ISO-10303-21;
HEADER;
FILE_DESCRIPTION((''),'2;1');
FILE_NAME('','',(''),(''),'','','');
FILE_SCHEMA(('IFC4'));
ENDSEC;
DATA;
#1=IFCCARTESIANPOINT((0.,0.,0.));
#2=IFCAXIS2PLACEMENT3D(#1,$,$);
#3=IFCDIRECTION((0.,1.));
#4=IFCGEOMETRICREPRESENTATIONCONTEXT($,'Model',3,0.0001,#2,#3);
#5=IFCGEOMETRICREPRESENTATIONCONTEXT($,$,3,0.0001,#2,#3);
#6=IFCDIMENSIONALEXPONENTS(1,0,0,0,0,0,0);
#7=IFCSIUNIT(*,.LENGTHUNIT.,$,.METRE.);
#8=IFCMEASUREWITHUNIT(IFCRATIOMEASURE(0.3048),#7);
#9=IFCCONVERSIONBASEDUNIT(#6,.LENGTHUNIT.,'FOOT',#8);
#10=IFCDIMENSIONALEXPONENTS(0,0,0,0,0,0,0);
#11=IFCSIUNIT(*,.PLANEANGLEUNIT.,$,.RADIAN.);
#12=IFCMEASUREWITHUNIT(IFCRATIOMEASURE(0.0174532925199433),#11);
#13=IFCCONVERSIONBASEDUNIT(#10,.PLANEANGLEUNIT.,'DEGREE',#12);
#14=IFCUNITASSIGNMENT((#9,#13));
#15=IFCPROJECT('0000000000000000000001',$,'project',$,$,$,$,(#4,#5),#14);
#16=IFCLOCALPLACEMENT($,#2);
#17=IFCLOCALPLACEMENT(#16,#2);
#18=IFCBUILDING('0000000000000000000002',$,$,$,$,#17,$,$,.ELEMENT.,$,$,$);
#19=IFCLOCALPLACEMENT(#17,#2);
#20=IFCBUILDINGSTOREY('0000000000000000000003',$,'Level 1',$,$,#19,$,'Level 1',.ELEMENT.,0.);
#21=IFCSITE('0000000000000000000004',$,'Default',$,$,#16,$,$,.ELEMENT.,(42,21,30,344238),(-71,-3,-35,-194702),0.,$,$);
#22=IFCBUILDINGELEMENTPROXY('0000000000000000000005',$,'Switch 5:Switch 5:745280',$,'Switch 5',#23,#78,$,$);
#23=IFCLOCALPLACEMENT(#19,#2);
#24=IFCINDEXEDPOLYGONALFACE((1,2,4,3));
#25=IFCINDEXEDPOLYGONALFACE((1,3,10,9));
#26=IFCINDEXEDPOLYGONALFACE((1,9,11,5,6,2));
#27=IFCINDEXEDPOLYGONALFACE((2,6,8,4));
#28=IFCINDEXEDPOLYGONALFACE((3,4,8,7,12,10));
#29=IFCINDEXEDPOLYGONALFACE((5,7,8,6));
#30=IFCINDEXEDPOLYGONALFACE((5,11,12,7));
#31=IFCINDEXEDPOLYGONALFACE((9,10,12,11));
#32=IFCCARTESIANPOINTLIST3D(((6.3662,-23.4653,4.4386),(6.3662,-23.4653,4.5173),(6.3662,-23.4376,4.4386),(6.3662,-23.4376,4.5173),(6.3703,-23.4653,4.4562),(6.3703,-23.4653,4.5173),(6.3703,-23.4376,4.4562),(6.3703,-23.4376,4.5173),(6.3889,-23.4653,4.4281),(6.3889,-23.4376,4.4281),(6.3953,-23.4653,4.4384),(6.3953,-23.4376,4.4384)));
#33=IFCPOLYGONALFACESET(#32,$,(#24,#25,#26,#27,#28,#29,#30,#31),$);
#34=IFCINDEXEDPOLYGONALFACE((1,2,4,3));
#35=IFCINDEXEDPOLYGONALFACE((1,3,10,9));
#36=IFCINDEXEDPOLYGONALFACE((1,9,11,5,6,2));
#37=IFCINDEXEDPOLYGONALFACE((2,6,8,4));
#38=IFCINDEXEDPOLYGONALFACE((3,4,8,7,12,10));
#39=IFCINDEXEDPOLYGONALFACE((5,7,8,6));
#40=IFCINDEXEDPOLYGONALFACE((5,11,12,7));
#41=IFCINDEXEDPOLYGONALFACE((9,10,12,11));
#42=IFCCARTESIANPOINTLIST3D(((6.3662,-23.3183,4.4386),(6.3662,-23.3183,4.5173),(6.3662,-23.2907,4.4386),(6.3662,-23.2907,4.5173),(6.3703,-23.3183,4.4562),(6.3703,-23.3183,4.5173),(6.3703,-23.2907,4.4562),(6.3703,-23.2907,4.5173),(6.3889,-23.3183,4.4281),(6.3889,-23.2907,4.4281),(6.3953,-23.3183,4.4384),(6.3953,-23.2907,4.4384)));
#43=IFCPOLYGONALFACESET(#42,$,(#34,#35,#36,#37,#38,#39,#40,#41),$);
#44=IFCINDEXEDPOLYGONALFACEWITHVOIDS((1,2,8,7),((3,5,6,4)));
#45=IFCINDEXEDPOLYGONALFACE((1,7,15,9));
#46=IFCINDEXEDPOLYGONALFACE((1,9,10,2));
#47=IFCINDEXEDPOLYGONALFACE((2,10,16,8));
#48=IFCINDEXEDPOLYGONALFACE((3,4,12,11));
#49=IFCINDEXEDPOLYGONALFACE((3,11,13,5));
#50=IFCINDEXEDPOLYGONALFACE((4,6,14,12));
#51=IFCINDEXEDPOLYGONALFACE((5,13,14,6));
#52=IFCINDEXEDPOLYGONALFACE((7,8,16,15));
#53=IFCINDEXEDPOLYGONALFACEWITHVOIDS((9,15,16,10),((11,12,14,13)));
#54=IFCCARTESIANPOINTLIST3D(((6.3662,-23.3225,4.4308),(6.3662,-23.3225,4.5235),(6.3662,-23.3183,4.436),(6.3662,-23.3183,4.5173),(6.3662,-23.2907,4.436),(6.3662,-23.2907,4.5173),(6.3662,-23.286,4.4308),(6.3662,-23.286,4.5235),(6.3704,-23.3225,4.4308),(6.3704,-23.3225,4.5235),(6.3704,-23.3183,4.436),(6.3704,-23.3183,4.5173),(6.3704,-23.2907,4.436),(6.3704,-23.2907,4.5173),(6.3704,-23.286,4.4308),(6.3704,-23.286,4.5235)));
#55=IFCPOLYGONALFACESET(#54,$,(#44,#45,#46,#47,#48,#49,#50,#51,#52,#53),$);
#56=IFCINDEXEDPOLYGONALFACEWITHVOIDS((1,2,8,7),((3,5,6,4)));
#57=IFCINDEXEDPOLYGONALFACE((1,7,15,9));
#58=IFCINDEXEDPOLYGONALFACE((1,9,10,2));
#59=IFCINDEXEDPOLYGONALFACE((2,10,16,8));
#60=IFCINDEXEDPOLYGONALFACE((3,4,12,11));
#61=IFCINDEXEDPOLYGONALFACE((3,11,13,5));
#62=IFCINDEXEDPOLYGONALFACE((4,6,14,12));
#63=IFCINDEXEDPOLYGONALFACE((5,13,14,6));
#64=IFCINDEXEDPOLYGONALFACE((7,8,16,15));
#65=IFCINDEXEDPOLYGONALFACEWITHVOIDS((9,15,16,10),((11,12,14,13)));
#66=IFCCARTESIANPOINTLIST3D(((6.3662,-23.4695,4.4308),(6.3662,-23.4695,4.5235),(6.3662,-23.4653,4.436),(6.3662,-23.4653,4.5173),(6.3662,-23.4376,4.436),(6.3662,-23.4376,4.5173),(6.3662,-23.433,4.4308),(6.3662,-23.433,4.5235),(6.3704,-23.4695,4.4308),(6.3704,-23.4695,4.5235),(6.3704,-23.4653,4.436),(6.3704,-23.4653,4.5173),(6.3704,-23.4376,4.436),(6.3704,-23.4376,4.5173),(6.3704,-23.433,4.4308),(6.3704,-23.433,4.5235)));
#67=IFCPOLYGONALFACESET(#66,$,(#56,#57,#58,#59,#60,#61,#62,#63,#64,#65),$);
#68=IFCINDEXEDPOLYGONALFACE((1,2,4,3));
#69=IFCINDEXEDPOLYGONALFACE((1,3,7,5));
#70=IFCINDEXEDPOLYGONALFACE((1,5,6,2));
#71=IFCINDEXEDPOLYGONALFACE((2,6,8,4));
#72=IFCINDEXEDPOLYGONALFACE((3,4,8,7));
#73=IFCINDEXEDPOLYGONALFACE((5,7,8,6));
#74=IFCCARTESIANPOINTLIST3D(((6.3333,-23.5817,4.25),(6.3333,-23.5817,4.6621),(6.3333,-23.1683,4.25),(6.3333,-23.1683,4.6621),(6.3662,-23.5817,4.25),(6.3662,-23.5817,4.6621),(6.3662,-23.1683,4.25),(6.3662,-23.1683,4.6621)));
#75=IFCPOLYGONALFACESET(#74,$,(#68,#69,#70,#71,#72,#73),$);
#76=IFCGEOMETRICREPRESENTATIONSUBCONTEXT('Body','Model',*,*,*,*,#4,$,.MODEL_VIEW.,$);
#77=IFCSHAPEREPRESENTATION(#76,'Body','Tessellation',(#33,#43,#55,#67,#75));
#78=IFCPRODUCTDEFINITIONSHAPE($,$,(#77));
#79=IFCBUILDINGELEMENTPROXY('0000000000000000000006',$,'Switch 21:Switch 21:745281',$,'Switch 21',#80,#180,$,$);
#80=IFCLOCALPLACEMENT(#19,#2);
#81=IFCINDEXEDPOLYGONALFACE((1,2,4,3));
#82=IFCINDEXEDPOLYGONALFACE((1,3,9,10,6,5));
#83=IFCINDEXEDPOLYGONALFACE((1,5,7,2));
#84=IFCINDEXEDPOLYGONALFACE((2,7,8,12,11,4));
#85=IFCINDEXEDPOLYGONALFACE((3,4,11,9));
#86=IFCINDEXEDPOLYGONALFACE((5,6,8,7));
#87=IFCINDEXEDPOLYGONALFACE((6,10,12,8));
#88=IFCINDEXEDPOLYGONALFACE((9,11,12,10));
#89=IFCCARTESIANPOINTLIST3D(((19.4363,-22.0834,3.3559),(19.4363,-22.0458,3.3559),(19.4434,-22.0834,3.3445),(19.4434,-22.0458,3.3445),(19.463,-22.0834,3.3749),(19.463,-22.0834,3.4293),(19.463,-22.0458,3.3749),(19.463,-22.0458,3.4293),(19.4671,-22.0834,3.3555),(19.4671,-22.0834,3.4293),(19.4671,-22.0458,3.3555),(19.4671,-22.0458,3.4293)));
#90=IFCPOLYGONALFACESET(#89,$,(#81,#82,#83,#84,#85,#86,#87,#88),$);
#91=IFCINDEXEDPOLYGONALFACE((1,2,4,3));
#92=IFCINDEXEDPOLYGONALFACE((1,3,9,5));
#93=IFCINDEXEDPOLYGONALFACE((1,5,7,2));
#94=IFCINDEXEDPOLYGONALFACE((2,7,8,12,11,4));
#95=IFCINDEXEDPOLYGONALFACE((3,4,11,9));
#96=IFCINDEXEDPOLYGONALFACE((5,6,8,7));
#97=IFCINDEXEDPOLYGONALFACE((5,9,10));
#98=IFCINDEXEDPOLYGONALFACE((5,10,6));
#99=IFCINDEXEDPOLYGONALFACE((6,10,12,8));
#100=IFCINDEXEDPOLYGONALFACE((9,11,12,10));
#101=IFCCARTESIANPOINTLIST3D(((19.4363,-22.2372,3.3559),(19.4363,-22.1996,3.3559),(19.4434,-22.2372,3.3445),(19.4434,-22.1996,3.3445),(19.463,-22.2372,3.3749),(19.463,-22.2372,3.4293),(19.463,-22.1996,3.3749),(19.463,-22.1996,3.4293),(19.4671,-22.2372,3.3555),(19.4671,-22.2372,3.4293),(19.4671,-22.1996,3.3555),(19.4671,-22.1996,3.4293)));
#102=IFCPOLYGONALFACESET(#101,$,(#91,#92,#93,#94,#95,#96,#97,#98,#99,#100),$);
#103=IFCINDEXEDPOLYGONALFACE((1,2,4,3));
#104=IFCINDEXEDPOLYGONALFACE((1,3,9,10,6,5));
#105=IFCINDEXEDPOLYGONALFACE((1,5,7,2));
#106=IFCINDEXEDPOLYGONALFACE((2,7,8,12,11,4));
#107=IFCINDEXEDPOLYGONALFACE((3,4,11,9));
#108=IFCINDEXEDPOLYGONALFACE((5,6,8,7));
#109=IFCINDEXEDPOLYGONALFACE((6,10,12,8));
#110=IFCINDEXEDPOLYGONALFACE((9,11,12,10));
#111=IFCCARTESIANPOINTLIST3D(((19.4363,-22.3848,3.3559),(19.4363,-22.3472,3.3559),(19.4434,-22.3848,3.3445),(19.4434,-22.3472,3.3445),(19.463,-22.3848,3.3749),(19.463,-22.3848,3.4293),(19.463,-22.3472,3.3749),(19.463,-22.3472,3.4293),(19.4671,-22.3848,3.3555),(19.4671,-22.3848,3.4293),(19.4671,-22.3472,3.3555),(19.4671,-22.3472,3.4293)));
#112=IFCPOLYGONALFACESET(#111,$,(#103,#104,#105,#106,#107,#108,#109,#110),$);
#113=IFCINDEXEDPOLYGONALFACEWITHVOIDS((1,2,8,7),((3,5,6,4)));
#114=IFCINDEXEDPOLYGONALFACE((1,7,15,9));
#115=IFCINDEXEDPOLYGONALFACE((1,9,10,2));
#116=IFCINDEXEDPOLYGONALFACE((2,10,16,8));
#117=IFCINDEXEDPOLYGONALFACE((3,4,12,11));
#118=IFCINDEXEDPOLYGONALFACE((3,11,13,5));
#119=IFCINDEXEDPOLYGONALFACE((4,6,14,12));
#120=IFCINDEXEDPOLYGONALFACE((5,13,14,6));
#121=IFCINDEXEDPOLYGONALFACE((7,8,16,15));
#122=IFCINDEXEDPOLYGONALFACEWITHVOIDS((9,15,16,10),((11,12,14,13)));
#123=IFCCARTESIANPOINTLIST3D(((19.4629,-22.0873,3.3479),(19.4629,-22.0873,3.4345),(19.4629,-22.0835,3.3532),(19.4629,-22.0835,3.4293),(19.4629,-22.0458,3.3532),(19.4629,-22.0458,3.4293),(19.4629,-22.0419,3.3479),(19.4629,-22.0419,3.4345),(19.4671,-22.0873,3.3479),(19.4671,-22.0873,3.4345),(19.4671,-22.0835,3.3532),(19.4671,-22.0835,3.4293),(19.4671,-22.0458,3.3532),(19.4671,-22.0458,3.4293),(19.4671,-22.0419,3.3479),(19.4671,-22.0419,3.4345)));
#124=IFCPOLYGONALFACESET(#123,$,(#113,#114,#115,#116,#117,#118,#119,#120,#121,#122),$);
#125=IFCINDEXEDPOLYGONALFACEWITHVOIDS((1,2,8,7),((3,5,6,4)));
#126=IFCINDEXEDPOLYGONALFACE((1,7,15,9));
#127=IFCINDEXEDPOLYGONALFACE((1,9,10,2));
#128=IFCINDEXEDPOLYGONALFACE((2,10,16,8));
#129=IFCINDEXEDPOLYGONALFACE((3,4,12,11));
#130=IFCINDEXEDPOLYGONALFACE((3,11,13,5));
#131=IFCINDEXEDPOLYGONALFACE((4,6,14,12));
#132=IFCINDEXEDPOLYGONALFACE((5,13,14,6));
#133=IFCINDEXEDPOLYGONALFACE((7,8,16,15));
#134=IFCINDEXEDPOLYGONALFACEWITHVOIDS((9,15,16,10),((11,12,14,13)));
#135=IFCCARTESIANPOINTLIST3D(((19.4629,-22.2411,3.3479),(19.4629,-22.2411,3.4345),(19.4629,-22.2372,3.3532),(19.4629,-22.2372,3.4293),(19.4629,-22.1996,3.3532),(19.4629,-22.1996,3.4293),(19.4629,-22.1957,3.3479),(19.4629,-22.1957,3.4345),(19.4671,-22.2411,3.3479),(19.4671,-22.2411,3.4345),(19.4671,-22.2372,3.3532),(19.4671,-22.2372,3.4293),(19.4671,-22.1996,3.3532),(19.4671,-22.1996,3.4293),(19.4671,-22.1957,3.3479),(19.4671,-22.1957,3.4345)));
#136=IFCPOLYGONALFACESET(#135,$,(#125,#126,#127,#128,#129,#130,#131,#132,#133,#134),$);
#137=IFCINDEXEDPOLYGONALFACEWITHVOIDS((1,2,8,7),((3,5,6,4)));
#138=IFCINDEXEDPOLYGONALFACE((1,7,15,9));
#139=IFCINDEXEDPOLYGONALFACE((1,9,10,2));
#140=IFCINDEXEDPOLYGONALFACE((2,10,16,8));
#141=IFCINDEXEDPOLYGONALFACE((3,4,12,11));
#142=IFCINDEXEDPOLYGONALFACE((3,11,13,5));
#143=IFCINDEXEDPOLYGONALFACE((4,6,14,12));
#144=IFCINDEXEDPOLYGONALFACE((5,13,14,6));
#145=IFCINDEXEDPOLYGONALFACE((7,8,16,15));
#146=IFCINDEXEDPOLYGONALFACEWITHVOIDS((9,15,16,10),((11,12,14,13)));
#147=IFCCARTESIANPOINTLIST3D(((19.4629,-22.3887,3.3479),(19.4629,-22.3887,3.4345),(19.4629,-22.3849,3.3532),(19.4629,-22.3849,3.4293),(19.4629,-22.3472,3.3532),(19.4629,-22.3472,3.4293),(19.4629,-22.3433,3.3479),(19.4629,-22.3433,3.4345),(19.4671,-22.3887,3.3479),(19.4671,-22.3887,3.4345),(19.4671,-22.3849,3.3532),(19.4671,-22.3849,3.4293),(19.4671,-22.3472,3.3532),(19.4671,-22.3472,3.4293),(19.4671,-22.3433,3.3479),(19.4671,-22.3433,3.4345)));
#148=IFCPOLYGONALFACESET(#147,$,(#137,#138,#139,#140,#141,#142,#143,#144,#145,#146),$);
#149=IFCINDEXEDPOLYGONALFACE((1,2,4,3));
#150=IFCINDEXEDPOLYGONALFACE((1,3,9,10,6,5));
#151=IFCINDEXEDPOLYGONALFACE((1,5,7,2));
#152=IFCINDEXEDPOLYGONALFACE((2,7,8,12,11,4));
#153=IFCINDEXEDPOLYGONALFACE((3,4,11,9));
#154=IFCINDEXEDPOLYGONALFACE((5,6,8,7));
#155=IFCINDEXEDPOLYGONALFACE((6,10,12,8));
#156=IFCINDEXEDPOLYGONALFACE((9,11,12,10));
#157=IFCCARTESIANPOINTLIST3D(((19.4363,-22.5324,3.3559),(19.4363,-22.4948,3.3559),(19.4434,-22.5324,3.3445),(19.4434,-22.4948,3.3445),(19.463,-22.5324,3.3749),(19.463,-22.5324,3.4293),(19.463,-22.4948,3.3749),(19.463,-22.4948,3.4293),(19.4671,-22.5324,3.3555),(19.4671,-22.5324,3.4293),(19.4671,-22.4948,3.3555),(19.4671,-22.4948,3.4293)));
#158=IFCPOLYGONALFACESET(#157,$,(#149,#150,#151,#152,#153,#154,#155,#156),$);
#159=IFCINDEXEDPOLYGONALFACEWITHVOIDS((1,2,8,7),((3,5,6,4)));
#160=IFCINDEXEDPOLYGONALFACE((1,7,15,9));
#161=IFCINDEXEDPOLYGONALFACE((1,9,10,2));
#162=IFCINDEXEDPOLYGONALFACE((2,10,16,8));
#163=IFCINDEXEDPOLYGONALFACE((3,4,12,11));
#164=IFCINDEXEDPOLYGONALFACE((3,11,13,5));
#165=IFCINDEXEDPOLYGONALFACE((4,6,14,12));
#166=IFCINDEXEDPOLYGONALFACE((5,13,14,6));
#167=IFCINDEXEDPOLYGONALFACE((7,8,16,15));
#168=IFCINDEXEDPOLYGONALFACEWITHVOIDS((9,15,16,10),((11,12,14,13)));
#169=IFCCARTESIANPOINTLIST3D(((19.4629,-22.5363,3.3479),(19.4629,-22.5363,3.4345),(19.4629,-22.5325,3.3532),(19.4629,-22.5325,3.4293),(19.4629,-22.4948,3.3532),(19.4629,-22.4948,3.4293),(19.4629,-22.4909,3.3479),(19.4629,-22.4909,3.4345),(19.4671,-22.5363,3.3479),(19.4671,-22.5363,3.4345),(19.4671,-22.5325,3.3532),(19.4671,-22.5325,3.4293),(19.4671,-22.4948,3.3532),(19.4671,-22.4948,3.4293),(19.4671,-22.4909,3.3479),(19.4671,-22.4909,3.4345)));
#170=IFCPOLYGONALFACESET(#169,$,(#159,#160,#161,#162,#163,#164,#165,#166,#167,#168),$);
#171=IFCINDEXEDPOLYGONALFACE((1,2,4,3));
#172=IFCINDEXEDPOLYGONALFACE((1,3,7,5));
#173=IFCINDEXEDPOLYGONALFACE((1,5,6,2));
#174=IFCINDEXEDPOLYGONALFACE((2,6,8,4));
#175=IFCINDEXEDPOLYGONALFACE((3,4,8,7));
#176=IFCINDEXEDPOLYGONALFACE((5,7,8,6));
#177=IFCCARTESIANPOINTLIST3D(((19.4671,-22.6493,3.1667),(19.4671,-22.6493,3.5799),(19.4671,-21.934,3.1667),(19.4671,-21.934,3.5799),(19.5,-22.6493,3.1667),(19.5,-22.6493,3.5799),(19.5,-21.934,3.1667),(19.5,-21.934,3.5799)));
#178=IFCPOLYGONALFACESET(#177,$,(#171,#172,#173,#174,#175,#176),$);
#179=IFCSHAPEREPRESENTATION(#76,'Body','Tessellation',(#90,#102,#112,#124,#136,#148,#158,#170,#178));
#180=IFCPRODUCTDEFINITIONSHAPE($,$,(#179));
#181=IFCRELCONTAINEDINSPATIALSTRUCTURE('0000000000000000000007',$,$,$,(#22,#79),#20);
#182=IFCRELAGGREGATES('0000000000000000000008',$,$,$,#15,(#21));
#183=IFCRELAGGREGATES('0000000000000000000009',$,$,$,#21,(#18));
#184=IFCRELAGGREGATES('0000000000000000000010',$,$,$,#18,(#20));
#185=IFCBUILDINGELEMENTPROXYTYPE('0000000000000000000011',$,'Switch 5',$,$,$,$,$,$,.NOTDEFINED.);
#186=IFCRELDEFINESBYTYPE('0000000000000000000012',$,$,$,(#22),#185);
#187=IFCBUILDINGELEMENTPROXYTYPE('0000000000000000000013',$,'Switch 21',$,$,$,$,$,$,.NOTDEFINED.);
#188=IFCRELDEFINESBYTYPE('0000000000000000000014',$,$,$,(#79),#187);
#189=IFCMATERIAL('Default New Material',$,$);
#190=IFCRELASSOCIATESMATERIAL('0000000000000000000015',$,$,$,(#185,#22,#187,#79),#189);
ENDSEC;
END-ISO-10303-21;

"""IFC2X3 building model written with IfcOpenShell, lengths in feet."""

from ifc_helpers import new_model, entity, si_unit, converted_unit, direction, frame, origin, origin_2d_with_axis, place, context, subcontext, project, spatial, polyline, rectangle, outline, extrude, source, transform, mapped, material, type_object, type_shapes, element, save


model = new_model("IFC2X3")

# Units and contexts
model_context = context("Model", 3, precision=0.0001, world=origin(), true_north=direction((0.0, 1.0)))
context_of_model = context(None, 3, precision=0.0001, world=origin(), true_north=direction((0.0, 1.0)))
body_context = subcontext(model_context, "Body", "Model", "MODEL_VIEW")
ifc_project = project(units=[converted_unit("LENGTHUNIT", "FOOT", entity("IfcRatioMeasure", 0.3048), si_unit("LENGTHUNIT", "METRE"), dimensions=[1, 0, 0, 0, 0, 0, 0]), converted_unit("PLANEANGLEUNIT", "DEGREE", entity("IfcRatioMeasure", 0.0174532925199433), si_unit("PLANEANGLEUNIT", "RADIAN"), dimensions=[0, 0, 0, 0, 0, 0, 0])], contexts=[model_context, context_of_model])

# Site, building, storey
site_placement = place(None, origin())
site = spatial("IfcSite", under=ifc_project, at=site_placement, Name="Default", CompositionType="ELEMENT", RefLatitude=(42, 21, 30, 344238), RefLongitude=(-71, -3, -35, -194702), RefElevation=0.0)
building_placement = place(site_placement, origin())
building = spatial("IfcBuilding", under=site, at=building_placement, CompositionType="ELEMENT")
storey_placement = place(building_placement, origin())
storey = spatial("IfcBuildingStorey", under=building, at=storey_placement, Name="Level 1", LongName="Level 1", CompositionType="ELEMENT", Elevation=0.0)

# Shared definitions
ifc_material = material(Name="Default New Material")

# Building element proxies
building_element_proxy_type_1 = type_object("IfcBuildingElementProxyType", Name="Switch 5", PredefinedType="NOTDEFINED", material=ifc_material)
shared_shape_1 = source(origin(), body_context, "Body", "SweptSolid", [
    extrude(outline(polyline([(-0.0255, -0.0308), (-0.0133, -0.0308), (-0.0115, -0.0002), (0.0405, 0.0322), (0.0383, 0.0356), (-0.0285, -0.006), (-0.0255, -0.0308)])), frame((0.0626, 0.0429, 0.216), z_axis=(1.0, 0.0, 0.0), x_axis=(0.0, 0.528865, 0.848706)), (0.0, 0.0, 1.0), 0.0277),
    extrude(outline(polyline([(-0.0255, -0.0308), (-0.0133, -0.0308), (-0.0115, -0.0002), (0.0405, 0.0322), (0.0383, 0.0356), (-0.0285, -0.006), (-0.0255, -0.0308)])), frame((-0.0843, 0.0429, 0.216), z_axis=(1.0, 0.0, 0.0), x_axis=(0.0, 0.528865, 0.848706)), (0.0, 0.0, 1.0), 0.0277),
    extrude(outline(polyline([(-0.0464, -0.0182), (0.0464, -0.0182), (0.0464, 0.0182), (-0.0464, 0.0182), (-0.0464, -0.0182)]), holes=[polyline([(-0.0402, -0.0141), (-0.0402, 0.0136), (0.0411, 0.0136), (0.0411, -0.0141), (-0.0402, -0.0141)])]), frame((-0.0707, 0.0329, 0.2271), z_axis=(0.0, 1.0, 0.0), x_axis=(0.0, 0.0, -1.0)), (0.0, 0.0, 1.0), 0.0042),
    extrude(outline(polyline([(-0.0464, -0.0182), (0.0464, -0.0182), (0.0464, 0.0182), (-0.0464, 0.0182), (-0.0464, -0.0182)]), holes=[polyline([(-0.0402, -0.0141), (-0.0402, 0.0136), (0.0411, 0.0136), (0.0411, -0.0141), (-0.0402, -0.0141)])]), frame((0.0762, 0.0329, 0.2271), z_axis=(0.0, 1.0, 0.0), x_axis=(0.0, 0.0, -1.0)), (0.0, 0.0, 1.0), 0.0042),
    extrude(rectangle(XDim=0.0329, YDim=0.4134, at=origin_2d_with_axis()), frame((0.0, 0.0164, 0.0), z_axis=(0.0, 0.0, 1.0), x_axis=(0.0, -1.0, 0.0)), (0.0, 0.0, 1.0), 0.4121),
])
type_shapes(building_element_proxy_type_1, [shared_shape_1])
proxy_1_placement = place(storey_placement, frame((6.3333, -23.375, 4.25), z_axis=(0.0, 0.0, 1.0), x_axis=(0.0, -1.0, 0.0)))
element("IfcBuildingElementProxy", 1, at=proxy_1_placement, inside=storey, type_object=building_element_proxy_type_1, material=ifc_material, Name="Switch 5:Switch 5:745280", ObjectType="Switch 5", context=body_context, shape_type="MappedRepresentation", body=[
    mapped(shared_shape_1, transform((0.0, 0.0, 0.0), scale=1.0)),
])
building_element_proxy_type_2 = type_object("IfcBuildingElementProxyType", Name="Switch 21", PredefinedType="NOTDEFINED", material=ifc_material)
shared_shape_2 = source(origin(), body_context, "Body", "SweptSolid", [
    extrude(outline(polyline([(-0.0245, -0.0309), (-0.011, -0.0309), (-0.009, 0.0019), (0.0372, 0.0307), (0.035, 0.0341), (-0.0277, -0.0049), (-0.0245, -0.0309)])), frame((0.2083, 0.0433, 0.2149), z_axis=(1.0, 0.0, 0.0), x_axis=(0.0, 0.528865, 0.848706)), (0.0, 0.0, 1.0), 0.0376),
    extrude(outline(polyline([(-0.0245, -0.0309), (-0.011, -0.0309), (-0.009, 0.0019), (0.0372, 0.0307), (0.035, 0.0341), (-0.0277, -0.0049), (-0.0245, -0.0309)])), frame((0.0545, 0.0433, 0.2149), z_axis=(1.0, 0.0, 0.0), x_axis=(0.0, 0.528865, 0.848706)), (0.0, 0.0, 1.0), 0.0376),
    extrude(outline(polyline([(-0.0245, -0.0309), (-0.011, -0.0309), (-0.009, 0.0019), (0.0372, 0.0307), (0.035, 0.0341), (-0.0277, -0.0049), (-0.0245, -0.0309)])), frame((-0.0931, 0.0433, 0.2149), z_axis=(1.0, 0.0, 0.0), x_axis=(0.0, 0.528865, 0.848706)), (0.0, 0.0, 1.0), 0.0376),
    extrude(outline(polyline([(-0.0433, -0.0227), (0.0433, -0.0227), (0.0433, 0.0227), (-0.0433, 0.0227), (-0.0433, -0.0227)]), holes=[polyline([(-0.0381, -0.0188), (-0.0381, 0.0189), (0.038, 0.0189), (0.038, -0.0188), (-0.0381, -0.0188)])]), frame((0.2271, 0.0329, 0.2245), z_axis=(0.0, 1.0, 0.0), x_axis=(0.0, 0.0, -1.0)), (0.0, 0.0, 1.0), 0.0042),
    extrude(outline(polyline([(-0.0433, -0.0227), (0.0433, -0.0227), (0.0433, 0.0227), (-0.0433, 0.0227), (-0.0433, -0.0227)]), holes=[polyline([(-0.0381, -0.0188), (-0.0381, 0.0189), (0.038, 0.0189), (0.038, -0.0188), (-0.0381, -0.0188)])]), frame((0.0733, 0.0329, 0.2245), z_axis=(0.0, 1.0, 0.0), x_axis=(0.0, 0.0, -1.0)), (0.0, 0.0, 1.0), 0.0042),
    extrude(outline(polyline([(-0.0433, -0.0227), (0.0433, -0.0227), (0.0433, 0.0227), (-0.0433, 0.0227), (-0.0433, -0.0227)]), holes=[polyline([(-0.0381, -0.0188), (-0.0381, 0.0189), (0.038, 0.0189), (0.038, -0.0188), (-0.0381, -0.0188)])]), frame((-0.0743, 0.0329, 0.2245), z_axis=(0.0, 1.0, 0.0), x_axis=(0.0, 0.0, -1.0)), (0.0, 0.0, 1.0), 0.0042),
    extrude(outline(polyline([(-0.0245, -0.0309), (-0.011, -0.0309), (-0.009, 0.0019), (0.0372, 0.0307), (0.035, 0.0341), (-0.0277, -0.0049), (-0.0245, -0.0309)])), frame((-0.2408, 0.0433, 0.2149), z_axis=(1.0, 0.0, 0.0), x_axis=(0.0, 0.528865, 0.848706)), (0.0, 0.0, 1.0), 0.0376),
    extrude(outline(polyline([(-0.0433, -0.0227), (0.0433, -0.0227), (0.0433, 0.0227), (-0.0433, 0.0227), (-0.0433, -0.0227)]), holes=[polyline([(-0.0381, -0.0188), (-0.0381, 0.0189), (0.038, 0.0189), (0.038, -0.0188), (-0.0381, -0.0188)])]), frame((-0.222, 0.0329, 0.2245), z_axis=(0.0, 1.0, 0.0), x_axis=(0.0, 0.0, -1.0)), (0.0, 0.0, 1.0), 0.0042),
    extrude(rectangle(XDim=0.0329, YDim=0.7153, at=origin_2d_with_axis()), frame((0.0, 0.0164, 0.0), z_axis=(0.0, 0.0, 1.0), x_axis=(0.0, -1.0, 0.0)), (0.0, 0.0, 1.0), 0.4132),
])
type_shapes(building_element_proxy_type_2, [shared_shape_2])
proxy_2_placement = place(storey_placement, frame((19.5, -22.2917, 3.1667), z_axis=(0.0, 0.0, 1.0), x_axis=(0.0, 1.0, 0.0)))
element("IfcBuildingElementProxy", 2, at=proxy_2_placement, inside=storey, type_object=building_element_proxy_type_2, material=ifc_material, Name="Switch 21:Switch 21:745281", ObjectType="Switch 21", context=body_context, shape_type="MappedRepresentation", body=[
    mapped(shared_shape_2, transform((0.0, 0.0, 0.0), scale=1.0)),
])

save(model, "model.ifc")
